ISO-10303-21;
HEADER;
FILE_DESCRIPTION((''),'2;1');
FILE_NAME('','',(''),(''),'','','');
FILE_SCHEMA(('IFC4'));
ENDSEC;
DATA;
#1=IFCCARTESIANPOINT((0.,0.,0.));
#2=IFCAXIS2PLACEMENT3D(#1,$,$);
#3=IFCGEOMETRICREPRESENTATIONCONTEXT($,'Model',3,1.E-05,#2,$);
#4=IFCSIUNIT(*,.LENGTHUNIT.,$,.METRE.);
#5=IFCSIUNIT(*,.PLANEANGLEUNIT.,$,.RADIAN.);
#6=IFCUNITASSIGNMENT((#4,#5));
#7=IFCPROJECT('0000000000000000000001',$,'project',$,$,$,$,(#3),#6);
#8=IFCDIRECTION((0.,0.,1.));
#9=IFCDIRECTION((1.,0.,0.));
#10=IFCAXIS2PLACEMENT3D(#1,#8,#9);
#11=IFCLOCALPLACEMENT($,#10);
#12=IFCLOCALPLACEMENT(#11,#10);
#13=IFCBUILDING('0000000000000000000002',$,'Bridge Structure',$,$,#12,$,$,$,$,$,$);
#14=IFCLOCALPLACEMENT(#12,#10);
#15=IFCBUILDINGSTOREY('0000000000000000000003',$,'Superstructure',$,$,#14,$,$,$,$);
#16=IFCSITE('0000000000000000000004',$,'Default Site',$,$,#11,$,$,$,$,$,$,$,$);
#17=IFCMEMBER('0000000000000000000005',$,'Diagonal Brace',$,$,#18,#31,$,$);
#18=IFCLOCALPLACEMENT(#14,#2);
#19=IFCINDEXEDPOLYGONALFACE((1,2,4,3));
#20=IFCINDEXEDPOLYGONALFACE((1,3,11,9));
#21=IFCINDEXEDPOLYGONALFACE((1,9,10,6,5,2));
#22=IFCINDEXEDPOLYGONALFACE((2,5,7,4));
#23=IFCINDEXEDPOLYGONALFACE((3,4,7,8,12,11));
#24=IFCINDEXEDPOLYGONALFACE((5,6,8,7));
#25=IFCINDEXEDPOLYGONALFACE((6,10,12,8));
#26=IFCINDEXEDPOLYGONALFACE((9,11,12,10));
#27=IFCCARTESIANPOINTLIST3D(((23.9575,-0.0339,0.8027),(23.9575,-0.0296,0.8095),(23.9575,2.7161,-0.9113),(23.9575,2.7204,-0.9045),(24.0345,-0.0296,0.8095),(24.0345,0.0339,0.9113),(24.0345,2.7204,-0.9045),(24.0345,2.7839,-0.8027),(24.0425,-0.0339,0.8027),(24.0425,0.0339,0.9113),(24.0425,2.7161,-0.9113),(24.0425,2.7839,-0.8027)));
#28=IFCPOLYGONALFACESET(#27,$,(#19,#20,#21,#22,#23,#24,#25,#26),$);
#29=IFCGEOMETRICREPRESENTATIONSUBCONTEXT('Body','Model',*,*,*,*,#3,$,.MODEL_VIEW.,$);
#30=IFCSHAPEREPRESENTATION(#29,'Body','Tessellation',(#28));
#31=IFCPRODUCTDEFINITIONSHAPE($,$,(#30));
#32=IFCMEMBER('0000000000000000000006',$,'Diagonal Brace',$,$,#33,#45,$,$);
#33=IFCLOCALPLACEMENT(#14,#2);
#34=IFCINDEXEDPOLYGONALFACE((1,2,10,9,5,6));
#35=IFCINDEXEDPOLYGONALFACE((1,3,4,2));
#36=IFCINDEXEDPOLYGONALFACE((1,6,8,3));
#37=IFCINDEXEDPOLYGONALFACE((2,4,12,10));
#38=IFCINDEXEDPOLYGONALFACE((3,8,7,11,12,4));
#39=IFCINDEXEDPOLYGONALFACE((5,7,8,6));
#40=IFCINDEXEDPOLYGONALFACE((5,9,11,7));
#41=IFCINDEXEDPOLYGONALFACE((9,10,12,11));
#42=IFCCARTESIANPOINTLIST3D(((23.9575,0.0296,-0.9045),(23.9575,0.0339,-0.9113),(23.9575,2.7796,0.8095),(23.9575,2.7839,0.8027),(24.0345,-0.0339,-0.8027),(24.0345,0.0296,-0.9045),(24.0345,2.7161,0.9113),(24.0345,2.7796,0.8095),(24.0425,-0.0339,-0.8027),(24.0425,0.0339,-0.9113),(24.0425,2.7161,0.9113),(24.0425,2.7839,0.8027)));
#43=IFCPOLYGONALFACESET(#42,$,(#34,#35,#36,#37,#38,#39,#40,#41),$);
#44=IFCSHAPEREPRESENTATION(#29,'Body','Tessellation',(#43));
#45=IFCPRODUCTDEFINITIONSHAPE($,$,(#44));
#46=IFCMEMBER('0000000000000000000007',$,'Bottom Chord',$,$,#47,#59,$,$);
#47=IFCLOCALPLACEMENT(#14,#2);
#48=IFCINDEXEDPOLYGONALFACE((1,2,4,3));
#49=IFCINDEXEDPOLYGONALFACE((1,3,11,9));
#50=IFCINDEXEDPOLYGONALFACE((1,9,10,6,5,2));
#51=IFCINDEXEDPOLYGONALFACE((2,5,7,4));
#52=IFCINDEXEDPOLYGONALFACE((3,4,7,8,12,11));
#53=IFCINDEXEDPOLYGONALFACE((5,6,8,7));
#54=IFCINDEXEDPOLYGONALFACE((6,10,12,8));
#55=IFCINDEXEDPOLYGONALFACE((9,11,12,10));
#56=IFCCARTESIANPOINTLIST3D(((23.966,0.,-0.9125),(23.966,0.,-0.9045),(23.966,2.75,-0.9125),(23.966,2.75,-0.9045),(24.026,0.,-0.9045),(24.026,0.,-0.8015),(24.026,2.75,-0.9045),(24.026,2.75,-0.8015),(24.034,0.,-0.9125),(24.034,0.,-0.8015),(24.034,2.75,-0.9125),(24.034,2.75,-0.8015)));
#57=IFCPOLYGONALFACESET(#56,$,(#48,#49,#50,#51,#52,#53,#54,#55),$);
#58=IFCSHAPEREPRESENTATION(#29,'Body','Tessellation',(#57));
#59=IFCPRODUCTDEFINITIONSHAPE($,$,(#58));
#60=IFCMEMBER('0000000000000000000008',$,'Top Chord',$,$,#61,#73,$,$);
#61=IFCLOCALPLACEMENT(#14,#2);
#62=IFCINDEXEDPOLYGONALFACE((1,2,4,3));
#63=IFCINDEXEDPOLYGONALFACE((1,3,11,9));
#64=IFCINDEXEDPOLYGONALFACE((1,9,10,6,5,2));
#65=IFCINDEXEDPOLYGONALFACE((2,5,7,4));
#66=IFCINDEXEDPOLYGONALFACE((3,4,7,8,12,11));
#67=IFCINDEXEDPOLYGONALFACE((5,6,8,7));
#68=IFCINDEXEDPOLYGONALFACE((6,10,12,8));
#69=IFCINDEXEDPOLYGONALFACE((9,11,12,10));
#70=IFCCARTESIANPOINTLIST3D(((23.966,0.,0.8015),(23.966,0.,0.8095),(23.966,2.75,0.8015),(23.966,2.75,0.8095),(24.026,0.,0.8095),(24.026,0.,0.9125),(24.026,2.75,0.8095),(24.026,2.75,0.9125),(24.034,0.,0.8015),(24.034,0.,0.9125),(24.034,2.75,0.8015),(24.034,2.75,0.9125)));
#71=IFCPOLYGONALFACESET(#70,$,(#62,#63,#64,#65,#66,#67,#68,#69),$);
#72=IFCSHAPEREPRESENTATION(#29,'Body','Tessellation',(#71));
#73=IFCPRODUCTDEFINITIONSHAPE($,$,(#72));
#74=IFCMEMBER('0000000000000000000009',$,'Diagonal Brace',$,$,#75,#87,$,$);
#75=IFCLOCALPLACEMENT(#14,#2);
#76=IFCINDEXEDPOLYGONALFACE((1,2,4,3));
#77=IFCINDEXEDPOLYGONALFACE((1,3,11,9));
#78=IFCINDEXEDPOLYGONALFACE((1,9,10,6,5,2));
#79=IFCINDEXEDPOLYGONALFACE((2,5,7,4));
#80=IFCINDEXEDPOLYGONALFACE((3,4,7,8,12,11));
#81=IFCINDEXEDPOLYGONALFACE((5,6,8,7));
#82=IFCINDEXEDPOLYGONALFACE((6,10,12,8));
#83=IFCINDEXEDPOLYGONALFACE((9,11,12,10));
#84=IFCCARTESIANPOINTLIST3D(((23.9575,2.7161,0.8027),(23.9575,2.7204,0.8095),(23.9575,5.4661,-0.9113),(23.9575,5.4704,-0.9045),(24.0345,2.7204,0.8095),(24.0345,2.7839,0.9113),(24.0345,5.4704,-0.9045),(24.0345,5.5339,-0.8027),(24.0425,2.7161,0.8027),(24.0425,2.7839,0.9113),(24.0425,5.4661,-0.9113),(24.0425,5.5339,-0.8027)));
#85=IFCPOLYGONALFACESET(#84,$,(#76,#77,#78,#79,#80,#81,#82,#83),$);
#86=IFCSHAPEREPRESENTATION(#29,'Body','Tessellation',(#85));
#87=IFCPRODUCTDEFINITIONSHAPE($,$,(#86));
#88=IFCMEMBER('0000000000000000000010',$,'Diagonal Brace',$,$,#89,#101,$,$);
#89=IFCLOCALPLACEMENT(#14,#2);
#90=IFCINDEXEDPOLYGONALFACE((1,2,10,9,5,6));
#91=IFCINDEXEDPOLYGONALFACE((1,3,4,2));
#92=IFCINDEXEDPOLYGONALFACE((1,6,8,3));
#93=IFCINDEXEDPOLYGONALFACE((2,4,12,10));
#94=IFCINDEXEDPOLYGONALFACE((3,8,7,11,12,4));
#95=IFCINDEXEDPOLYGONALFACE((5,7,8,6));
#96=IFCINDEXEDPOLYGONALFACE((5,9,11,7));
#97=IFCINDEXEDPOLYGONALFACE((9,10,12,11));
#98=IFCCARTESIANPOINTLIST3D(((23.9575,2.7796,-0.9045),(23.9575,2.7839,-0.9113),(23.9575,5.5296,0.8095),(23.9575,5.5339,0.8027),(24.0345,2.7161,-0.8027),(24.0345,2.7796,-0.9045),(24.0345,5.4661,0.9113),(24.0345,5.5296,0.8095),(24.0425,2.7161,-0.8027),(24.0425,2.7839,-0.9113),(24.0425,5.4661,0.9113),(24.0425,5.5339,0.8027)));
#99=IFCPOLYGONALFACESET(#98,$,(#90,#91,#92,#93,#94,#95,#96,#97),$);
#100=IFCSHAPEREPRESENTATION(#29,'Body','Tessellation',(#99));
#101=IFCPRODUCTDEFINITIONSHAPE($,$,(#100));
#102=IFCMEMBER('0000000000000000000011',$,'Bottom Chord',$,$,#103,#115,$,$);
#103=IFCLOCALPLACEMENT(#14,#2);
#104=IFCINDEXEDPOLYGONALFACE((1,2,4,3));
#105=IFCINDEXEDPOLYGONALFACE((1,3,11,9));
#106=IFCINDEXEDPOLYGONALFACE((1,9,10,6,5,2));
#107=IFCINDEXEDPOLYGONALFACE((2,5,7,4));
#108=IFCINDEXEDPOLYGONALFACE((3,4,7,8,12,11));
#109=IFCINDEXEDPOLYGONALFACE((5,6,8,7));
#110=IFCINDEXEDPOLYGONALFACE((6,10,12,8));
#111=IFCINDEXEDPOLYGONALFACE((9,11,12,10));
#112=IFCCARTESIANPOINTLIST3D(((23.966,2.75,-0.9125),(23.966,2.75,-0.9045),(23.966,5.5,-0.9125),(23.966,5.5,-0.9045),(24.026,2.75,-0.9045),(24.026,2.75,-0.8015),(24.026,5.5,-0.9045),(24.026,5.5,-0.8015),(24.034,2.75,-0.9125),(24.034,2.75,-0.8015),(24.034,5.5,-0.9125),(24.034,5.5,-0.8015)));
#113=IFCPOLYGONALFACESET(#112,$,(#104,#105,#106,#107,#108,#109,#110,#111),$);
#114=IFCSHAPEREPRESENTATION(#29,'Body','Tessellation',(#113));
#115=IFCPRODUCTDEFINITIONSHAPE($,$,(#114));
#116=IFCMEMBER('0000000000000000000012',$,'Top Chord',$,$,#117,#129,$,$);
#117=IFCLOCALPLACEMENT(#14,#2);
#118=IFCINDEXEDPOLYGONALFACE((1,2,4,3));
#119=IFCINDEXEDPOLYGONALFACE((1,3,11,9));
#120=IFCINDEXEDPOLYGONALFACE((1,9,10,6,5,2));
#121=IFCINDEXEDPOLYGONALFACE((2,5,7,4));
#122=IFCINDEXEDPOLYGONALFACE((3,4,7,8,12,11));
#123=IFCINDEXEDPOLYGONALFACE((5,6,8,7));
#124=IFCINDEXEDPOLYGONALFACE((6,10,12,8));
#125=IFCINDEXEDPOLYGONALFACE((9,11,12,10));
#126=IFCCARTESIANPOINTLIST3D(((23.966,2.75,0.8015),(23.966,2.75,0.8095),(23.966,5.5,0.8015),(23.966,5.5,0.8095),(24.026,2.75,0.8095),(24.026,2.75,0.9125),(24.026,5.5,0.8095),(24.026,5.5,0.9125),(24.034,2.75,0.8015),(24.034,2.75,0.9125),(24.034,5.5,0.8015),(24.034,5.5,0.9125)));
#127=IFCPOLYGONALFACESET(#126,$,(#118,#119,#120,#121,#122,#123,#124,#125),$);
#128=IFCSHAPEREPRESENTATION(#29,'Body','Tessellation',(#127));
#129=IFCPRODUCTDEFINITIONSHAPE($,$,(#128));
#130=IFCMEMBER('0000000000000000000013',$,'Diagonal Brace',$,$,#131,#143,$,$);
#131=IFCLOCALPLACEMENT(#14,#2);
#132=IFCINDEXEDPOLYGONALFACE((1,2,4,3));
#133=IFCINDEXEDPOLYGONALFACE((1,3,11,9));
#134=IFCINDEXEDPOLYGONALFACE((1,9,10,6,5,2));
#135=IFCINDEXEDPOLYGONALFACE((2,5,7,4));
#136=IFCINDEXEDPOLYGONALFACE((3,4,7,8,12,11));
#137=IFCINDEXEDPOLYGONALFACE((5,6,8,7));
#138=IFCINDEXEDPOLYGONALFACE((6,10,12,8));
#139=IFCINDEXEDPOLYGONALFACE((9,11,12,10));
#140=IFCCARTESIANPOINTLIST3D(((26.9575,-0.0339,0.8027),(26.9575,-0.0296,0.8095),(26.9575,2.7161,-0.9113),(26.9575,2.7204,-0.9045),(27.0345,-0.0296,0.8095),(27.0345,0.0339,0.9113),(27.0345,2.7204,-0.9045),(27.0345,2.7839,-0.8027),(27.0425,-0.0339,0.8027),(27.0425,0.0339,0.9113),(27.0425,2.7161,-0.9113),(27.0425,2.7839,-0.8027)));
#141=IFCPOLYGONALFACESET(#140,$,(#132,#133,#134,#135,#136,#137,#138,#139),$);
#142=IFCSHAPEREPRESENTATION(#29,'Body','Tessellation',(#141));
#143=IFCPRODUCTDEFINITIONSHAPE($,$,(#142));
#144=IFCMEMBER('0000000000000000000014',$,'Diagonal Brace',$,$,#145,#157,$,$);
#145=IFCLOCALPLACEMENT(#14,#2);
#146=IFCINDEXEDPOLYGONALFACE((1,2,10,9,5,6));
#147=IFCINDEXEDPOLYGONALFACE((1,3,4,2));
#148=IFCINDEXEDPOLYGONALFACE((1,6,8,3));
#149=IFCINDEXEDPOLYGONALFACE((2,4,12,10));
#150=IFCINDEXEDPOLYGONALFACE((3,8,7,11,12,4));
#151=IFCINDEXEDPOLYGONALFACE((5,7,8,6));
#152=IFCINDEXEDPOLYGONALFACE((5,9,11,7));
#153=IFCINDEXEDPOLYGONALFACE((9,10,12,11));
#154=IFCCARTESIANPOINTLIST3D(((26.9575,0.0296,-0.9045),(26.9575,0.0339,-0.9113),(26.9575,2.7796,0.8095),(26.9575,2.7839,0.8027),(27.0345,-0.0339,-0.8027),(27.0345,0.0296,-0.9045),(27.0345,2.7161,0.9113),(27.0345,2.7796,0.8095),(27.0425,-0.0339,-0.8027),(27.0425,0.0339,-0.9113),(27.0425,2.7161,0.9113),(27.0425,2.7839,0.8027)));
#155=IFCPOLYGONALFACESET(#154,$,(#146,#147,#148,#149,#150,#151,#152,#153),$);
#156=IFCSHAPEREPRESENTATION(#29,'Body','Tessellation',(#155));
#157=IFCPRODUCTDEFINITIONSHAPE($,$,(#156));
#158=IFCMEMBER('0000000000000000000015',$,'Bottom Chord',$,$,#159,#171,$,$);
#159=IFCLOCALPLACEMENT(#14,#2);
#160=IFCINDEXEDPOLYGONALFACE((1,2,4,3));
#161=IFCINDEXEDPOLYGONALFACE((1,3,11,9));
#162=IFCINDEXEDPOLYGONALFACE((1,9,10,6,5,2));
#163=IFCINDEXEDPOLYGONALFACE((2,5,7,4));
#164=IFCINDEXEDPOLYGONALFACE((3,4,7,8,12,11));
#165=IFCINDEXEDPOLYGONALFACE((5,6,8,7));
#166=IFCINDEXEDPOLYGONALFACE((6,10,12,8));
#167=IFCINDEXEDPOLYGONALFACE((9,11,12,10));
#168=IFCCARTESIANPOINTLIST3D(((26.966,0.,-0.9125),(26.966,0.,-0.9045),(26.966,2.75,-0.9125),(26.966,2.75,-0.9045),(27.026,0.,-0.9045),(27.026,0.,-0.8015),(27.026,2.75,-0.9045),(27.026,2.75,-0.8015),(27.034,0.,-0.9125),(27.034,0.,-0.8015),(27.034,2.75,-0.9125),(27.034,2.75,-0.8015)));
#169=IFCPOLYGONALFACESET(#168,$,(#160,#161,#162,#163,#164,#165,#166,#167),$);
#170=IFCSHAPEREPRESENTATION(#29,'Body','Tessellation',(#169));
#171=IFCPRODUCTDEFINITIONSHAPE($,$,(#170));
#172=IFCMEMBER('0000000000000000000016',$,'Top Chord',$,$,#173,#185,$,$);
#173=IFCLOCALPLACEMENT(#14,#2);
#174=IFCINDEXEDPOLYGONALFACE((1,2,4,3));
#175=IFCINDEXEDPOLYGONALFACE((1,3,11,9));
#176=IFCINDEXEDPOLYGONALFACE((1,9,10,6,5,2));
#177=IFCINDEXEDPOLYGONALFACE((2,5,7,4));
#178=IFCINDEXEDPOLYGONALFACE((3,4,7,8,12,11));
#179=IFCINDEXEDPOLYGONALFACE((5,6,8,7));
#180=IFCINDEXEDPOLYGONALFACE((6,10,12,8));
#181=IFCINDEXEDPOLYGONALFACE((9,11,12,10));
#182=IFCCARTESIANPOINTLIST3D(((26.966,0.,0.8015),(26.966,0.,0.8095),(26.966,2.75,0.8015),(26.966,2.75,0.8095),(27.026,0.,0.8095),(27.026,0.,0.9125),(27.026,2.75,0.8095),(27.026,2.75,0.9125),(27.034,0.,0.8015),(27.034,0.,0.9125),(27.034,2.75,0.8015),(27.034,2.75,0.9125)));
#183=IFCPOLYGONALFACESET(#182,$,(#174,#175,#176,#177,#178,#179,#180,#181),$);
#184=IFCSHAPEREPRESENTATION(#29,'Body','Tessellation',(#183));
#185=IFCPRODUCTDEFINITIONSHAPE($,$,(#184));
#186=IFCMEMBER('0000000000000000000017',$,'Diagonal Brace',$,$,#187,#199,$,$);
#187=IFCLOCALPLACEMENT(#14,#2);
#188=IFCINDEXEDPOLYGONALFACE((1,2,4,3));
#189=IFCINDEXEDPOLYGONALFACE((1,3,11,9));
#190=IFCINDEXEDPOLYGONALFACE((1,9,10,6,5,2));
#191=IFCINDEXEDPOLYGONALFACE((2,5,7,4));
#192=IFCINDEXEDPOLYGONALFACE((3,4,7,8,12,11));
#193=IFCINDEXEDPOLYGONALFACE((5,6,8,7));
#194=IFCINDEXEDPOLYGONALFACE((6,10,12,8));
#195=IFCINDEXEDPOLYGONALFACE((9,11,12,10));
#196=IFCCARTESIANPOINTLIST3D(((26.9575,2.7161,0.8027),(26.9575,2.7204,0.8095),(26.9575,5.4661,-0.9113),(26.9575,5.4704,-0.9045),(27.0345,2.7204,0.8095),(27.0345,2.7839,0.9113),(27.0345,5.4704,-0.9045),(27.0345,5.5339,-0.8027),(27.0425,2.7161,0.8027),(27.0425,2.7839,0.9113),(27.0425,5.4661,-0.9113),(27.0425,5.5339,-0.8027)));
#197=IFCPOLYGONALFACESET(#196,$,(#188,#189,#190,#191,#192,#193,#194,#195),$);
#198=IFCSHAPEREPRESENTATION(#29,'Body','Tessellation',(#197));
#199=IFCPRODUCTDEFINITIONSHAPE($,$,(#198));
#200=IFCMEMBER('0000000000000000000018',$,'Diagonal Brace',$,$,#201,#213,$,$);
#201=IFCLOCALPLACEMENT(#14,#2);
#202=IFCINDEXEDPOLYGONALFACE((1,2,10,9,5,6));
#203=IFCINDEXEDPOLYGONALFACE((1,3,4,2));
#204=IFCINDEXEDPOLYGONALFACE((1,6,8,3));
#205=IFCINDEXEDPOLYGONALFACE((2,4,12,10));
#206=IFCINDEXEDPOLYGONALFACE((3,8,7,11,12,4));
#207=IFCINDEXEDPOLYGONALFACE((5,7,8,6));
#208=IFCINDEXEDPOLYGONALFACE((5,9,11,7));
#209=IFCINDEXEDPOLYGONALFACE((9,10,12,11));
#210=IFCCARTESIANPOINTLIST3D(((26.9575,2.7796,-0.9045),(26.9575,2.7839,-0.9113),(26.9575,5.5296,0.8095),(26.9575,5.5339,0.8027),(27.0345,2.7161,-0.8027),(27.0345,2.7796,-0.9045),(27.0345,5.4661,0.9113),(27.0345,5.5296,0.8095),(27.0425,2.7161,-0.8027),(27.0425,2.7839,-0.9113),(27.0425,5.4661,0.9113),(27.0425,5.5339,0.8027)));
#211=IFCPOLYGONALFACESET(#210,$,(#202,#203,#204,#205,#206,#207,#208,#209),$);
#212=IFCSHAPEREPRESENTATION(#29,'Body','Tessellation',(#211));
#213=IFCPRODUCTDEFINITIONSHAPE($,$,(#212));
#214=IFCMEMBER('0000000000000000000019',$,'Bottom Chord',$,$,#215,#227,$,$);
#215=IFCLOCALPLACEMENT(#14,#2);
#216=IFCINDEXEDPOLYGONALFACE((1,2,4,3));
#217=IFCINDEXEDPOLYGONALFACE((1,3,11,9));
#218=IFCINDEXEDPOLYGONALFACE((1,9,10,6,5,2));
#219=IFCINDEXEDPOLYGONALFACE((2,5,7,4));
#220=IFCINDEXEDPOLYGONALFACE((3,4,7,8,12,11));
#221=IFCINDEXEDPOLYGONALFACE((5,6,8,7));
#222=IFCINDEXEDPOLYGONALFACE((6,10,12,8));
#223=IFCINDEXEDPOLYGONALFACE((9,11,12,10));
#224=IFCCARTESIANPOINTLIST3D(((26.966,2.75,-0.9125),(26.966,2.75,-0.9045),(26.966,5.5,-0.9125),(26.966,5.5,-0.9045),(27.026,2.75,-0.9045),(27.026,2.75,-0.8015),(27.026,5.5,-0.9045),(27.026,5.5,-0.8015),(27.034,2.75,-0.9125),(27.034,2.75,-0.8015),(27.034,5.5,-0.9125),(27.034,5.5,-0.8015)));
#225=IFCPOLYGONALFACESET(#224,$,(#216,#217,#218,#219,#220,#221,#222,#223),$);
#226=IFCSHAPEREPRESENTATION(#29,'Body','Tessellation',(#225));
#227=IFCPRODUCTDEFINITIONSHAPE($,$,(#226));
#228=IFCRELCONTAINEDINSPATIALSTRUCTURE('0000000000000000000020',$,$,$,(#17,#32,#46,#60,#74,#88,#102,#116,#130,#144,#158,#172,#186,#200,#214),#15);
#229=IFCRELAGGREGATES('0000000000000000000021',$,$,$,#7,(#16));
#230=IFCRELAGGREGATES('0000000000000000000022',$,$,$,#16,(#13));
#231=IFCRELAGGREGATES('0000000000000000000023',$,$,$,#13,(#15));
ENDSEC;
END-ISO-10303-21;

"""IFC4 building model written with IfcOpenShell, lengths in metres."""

from ifc_helpers import new_model, si_unit, frame, origin, origin_with_axes, origin_2d_with_axis, place, context, subcontext, project, spatial, l_section, extrude, element, save


model = new_model("IFC4")

# Units and contexts
model_context = context("Model", 3, precision=1e-05, world=origin())
body_context = subcontext(model_context, "Body", "Model", "MODEL_VIEW")
ifc_project = project(units=[si_unit("LENGTHUNIT", "METRE"), si_unit("PLANEANGLEUNIT", "RADIAN")], contexts=[model_context])

# Site, building, storey
site_placement = place(None, origin_with_axes())
site = spatial("IfcSite", under=ifc_project, at=site_placement, Name="Default Site")
building_placement = place(site_placement, origin_with_axes())
building = spatial("IfcBuilding", under=site, at=building_placement, Name="Bridge Structure")
storey_placement = place(building_placement, origin_with_axes())
storey = spatial("IfcBuildingStorey", under=building, at=storey_placement, Name="Superstructure")

# Members
for number, where, z_axis, x_axis, name in (
    (1, (24.0, 0.0, 0.857), (0.0, 0.848656, -0.528944), (-1.0, 0.0, 0.0), "Diagonal Brace"),
    (2, (24.0, 0.0, -0.857), (0.0, 0.848656, 0.528944), (-1.0, 0.0, 0.0), "Diagonal Brace"),
):
    element("IfcMember", number, at=place(storey_placement, frame(where, z_axis=z_axis, x_axis=x_axis)), inside=storey, Name=name, context=body_context, shape_type="SweptSolid", body=[
        extrude(l_section(Depth=0.128, Width=0.085, Thickness=0.008, at=origin_2d_with_axis()), origin_with_axes(), (0.0, 0.0, 1.0), 3.2404),
    ])
for number, where, z_axis, x_axis, name in (
    (3, (24.0, 0.0, -0.857), (0.0, 1.0, 0.0), (-1.0, 0.0, 0.0), "Bottom Chord"),
    (4, (24.0, 0.0, 0.857), (0.0, 1.0, 0.0), (-1.0, 0.0, 0.0), "Top Chord"),
):
    element("IfcMember", number, at=place(storey_placement, frame(where, z_axis=z_axis, x_axis=x_axis)), inside=storey, Name=name, context=body_context, shape_type="SweptSolid", body=[
        extrude(l_section(Depth=0.111, Width=0.068, Thickness=0.008, at=origin_2d_with_axis()), origin_with_axes(), (0.0, 0.0, 1.0), 2.75),
    ])
for number, where, z_axis, x_axis, name in (
    (5, (24.0, 2.75, 0.857), (0.0, 0.848656, -0.528944), (-1.0, 0.0, 0.0), "Diagonal Brace"),
    (6, (24.0, 2.75, -0.857), (0.0, 0.848656, 0.528944), (-1.0, 0.0, 0.0), "Diagonal Brace"),
):
    element("IfcMember", number, at=place(storey_placement, frame(where, z_axis=z_axis, x_axis=x_axis)), inside=storey, Name=name, context=body_context, shape_type="SweptSolid", body=[
        extrude(l_section(Depth=0.128, Width=0.085, Thickness=0.008, at=origin_2d_with_axis()), origin_with_axes(), (0.0, 0.0, 1.0), 3.2404),
    ])
for number, where, z_axis, x_axis, name in (
    (7, (24.0, 2.75, -0.857), (0.0, 1.0, 0.0), (-1.0, 0.0, 0.0), "Bottom Chord"),
    (8, (24.0, 2.75, 0.857), (0.0, 1.0, 0.0), (-1.0, 0.0, 0.0), "Top Chord"),
):
    element("IfcMember", number, at=place(storey_placement, frame(where, z_axis=z_axis, x_axis=x_axis)), inside=storey, Name=name, context=body_context, shape_type="SweptSolid", body=[
        extrude(l_section(Depth=0.111, Width=0.068, Thickness=0.008, at=origin_2d_with_axis()), origin_with_axes(), (0.0, 0.0, 1.0), 2.75),
    ])
for number, where, z_axis, x_axis, name in (
    (9, (27.0, 0.0, 0.857), (0.0, 0.848656, -0.528944), (-1.0, 0.0, 0.0), "Diagonal Brace"),
    (10, (27.0, 0.0, -0.857), (0.0, 0.848656, 0.528944), (-1.0, 0.0, 0.0), "Diagonal Brace"),
):
    element("IfcMember", number, at=place(storey_placement, frame(where, z_axis=z_axis, x_axis=x_axis)), inside=storey, Name=name, context=body_context, shape_type="SweptSolid", body=[
        extrude(l_section(Depth=0.128, Width=0.085, Thickness=0.008, at=origin_2d_with_axis()), origin_with_axes(), (0.0, 0.0, 1.0), 3.2404),
    ])
for number, where, z_axis, x_axis, name in (
    (11, (27.0, 0.0, -0.857), (0.0, 1.0, 0.0), (-1.0, 0.0, 0.0), "Bottom Chord"),
    (12, (27.0, 0.0, 0.857), (0.0, 1.0, 0.0), (-1.0, 0.0, 0.0), "Top Chord"),
):
    element("IfcMember", number, at=place(storey_placement, frame(where, z_axis=z_axis, x_axis=x_axis)), inside=storey, Name=name, context=body_context, shape_type="SweptSolid", body=[
        extrude(l_section(Depth=0.111, Width=0.068, Thickness=0.008, at=origin_2d_with_axis()), origin_with_axes(), (0.0, 0.0, 1.0), 2.75),
    ])
for number, where, z_axis, x_axis, name in (
    (13, (27.0, 2.75, 0.857), (0.0, 0.848656, -0.528944), (-1.0, 0.0, 0.0), "Diagonal Brace"),
    (14, (27.0, 2.75, -0.857), (0.0, 0.848656, 0.528944), (-1.0, 0.0, 0.0), "Diagonal Brace"),
):
    element("IfcMember", number, at=place(storey_placement, frame(where, z_axis=z_axis, x_axis=x_axis)), inside=storey, Name=name, context=body_context, shape_type="SweptSolid", body=[
        extrude(l_section(Depth=0.128, Width=0.085, Thickness=0.008, at=origin_2d_with_axis()), origin_with_axes(), (0.0, 0.0, 1.0), 3.2404),
    ])
for number, where, z_axis, x_axis, name in (
    (15, (27.0, 2.75, -0.857), (0.0, 1.0, 0.0), (-1.0, 0.0, 0.0), "Bottom Chord"),
):
    element("IfcMember", number, at=place(storey_placement, frame(where, z_axis=z_axis, x_axis=x_axis)), inside=storey, Name=name, context=body_context, shape_type="SweptSolid", body=[
        extrude(l_section(Depth=0.111, Width=0.068, Thickness=0.008, at=origin_2d_with_axis()), origin_with_axes(), (0.0, 0.0, 1.0), 2.75),
    ])

save(model, "model.ifc")
